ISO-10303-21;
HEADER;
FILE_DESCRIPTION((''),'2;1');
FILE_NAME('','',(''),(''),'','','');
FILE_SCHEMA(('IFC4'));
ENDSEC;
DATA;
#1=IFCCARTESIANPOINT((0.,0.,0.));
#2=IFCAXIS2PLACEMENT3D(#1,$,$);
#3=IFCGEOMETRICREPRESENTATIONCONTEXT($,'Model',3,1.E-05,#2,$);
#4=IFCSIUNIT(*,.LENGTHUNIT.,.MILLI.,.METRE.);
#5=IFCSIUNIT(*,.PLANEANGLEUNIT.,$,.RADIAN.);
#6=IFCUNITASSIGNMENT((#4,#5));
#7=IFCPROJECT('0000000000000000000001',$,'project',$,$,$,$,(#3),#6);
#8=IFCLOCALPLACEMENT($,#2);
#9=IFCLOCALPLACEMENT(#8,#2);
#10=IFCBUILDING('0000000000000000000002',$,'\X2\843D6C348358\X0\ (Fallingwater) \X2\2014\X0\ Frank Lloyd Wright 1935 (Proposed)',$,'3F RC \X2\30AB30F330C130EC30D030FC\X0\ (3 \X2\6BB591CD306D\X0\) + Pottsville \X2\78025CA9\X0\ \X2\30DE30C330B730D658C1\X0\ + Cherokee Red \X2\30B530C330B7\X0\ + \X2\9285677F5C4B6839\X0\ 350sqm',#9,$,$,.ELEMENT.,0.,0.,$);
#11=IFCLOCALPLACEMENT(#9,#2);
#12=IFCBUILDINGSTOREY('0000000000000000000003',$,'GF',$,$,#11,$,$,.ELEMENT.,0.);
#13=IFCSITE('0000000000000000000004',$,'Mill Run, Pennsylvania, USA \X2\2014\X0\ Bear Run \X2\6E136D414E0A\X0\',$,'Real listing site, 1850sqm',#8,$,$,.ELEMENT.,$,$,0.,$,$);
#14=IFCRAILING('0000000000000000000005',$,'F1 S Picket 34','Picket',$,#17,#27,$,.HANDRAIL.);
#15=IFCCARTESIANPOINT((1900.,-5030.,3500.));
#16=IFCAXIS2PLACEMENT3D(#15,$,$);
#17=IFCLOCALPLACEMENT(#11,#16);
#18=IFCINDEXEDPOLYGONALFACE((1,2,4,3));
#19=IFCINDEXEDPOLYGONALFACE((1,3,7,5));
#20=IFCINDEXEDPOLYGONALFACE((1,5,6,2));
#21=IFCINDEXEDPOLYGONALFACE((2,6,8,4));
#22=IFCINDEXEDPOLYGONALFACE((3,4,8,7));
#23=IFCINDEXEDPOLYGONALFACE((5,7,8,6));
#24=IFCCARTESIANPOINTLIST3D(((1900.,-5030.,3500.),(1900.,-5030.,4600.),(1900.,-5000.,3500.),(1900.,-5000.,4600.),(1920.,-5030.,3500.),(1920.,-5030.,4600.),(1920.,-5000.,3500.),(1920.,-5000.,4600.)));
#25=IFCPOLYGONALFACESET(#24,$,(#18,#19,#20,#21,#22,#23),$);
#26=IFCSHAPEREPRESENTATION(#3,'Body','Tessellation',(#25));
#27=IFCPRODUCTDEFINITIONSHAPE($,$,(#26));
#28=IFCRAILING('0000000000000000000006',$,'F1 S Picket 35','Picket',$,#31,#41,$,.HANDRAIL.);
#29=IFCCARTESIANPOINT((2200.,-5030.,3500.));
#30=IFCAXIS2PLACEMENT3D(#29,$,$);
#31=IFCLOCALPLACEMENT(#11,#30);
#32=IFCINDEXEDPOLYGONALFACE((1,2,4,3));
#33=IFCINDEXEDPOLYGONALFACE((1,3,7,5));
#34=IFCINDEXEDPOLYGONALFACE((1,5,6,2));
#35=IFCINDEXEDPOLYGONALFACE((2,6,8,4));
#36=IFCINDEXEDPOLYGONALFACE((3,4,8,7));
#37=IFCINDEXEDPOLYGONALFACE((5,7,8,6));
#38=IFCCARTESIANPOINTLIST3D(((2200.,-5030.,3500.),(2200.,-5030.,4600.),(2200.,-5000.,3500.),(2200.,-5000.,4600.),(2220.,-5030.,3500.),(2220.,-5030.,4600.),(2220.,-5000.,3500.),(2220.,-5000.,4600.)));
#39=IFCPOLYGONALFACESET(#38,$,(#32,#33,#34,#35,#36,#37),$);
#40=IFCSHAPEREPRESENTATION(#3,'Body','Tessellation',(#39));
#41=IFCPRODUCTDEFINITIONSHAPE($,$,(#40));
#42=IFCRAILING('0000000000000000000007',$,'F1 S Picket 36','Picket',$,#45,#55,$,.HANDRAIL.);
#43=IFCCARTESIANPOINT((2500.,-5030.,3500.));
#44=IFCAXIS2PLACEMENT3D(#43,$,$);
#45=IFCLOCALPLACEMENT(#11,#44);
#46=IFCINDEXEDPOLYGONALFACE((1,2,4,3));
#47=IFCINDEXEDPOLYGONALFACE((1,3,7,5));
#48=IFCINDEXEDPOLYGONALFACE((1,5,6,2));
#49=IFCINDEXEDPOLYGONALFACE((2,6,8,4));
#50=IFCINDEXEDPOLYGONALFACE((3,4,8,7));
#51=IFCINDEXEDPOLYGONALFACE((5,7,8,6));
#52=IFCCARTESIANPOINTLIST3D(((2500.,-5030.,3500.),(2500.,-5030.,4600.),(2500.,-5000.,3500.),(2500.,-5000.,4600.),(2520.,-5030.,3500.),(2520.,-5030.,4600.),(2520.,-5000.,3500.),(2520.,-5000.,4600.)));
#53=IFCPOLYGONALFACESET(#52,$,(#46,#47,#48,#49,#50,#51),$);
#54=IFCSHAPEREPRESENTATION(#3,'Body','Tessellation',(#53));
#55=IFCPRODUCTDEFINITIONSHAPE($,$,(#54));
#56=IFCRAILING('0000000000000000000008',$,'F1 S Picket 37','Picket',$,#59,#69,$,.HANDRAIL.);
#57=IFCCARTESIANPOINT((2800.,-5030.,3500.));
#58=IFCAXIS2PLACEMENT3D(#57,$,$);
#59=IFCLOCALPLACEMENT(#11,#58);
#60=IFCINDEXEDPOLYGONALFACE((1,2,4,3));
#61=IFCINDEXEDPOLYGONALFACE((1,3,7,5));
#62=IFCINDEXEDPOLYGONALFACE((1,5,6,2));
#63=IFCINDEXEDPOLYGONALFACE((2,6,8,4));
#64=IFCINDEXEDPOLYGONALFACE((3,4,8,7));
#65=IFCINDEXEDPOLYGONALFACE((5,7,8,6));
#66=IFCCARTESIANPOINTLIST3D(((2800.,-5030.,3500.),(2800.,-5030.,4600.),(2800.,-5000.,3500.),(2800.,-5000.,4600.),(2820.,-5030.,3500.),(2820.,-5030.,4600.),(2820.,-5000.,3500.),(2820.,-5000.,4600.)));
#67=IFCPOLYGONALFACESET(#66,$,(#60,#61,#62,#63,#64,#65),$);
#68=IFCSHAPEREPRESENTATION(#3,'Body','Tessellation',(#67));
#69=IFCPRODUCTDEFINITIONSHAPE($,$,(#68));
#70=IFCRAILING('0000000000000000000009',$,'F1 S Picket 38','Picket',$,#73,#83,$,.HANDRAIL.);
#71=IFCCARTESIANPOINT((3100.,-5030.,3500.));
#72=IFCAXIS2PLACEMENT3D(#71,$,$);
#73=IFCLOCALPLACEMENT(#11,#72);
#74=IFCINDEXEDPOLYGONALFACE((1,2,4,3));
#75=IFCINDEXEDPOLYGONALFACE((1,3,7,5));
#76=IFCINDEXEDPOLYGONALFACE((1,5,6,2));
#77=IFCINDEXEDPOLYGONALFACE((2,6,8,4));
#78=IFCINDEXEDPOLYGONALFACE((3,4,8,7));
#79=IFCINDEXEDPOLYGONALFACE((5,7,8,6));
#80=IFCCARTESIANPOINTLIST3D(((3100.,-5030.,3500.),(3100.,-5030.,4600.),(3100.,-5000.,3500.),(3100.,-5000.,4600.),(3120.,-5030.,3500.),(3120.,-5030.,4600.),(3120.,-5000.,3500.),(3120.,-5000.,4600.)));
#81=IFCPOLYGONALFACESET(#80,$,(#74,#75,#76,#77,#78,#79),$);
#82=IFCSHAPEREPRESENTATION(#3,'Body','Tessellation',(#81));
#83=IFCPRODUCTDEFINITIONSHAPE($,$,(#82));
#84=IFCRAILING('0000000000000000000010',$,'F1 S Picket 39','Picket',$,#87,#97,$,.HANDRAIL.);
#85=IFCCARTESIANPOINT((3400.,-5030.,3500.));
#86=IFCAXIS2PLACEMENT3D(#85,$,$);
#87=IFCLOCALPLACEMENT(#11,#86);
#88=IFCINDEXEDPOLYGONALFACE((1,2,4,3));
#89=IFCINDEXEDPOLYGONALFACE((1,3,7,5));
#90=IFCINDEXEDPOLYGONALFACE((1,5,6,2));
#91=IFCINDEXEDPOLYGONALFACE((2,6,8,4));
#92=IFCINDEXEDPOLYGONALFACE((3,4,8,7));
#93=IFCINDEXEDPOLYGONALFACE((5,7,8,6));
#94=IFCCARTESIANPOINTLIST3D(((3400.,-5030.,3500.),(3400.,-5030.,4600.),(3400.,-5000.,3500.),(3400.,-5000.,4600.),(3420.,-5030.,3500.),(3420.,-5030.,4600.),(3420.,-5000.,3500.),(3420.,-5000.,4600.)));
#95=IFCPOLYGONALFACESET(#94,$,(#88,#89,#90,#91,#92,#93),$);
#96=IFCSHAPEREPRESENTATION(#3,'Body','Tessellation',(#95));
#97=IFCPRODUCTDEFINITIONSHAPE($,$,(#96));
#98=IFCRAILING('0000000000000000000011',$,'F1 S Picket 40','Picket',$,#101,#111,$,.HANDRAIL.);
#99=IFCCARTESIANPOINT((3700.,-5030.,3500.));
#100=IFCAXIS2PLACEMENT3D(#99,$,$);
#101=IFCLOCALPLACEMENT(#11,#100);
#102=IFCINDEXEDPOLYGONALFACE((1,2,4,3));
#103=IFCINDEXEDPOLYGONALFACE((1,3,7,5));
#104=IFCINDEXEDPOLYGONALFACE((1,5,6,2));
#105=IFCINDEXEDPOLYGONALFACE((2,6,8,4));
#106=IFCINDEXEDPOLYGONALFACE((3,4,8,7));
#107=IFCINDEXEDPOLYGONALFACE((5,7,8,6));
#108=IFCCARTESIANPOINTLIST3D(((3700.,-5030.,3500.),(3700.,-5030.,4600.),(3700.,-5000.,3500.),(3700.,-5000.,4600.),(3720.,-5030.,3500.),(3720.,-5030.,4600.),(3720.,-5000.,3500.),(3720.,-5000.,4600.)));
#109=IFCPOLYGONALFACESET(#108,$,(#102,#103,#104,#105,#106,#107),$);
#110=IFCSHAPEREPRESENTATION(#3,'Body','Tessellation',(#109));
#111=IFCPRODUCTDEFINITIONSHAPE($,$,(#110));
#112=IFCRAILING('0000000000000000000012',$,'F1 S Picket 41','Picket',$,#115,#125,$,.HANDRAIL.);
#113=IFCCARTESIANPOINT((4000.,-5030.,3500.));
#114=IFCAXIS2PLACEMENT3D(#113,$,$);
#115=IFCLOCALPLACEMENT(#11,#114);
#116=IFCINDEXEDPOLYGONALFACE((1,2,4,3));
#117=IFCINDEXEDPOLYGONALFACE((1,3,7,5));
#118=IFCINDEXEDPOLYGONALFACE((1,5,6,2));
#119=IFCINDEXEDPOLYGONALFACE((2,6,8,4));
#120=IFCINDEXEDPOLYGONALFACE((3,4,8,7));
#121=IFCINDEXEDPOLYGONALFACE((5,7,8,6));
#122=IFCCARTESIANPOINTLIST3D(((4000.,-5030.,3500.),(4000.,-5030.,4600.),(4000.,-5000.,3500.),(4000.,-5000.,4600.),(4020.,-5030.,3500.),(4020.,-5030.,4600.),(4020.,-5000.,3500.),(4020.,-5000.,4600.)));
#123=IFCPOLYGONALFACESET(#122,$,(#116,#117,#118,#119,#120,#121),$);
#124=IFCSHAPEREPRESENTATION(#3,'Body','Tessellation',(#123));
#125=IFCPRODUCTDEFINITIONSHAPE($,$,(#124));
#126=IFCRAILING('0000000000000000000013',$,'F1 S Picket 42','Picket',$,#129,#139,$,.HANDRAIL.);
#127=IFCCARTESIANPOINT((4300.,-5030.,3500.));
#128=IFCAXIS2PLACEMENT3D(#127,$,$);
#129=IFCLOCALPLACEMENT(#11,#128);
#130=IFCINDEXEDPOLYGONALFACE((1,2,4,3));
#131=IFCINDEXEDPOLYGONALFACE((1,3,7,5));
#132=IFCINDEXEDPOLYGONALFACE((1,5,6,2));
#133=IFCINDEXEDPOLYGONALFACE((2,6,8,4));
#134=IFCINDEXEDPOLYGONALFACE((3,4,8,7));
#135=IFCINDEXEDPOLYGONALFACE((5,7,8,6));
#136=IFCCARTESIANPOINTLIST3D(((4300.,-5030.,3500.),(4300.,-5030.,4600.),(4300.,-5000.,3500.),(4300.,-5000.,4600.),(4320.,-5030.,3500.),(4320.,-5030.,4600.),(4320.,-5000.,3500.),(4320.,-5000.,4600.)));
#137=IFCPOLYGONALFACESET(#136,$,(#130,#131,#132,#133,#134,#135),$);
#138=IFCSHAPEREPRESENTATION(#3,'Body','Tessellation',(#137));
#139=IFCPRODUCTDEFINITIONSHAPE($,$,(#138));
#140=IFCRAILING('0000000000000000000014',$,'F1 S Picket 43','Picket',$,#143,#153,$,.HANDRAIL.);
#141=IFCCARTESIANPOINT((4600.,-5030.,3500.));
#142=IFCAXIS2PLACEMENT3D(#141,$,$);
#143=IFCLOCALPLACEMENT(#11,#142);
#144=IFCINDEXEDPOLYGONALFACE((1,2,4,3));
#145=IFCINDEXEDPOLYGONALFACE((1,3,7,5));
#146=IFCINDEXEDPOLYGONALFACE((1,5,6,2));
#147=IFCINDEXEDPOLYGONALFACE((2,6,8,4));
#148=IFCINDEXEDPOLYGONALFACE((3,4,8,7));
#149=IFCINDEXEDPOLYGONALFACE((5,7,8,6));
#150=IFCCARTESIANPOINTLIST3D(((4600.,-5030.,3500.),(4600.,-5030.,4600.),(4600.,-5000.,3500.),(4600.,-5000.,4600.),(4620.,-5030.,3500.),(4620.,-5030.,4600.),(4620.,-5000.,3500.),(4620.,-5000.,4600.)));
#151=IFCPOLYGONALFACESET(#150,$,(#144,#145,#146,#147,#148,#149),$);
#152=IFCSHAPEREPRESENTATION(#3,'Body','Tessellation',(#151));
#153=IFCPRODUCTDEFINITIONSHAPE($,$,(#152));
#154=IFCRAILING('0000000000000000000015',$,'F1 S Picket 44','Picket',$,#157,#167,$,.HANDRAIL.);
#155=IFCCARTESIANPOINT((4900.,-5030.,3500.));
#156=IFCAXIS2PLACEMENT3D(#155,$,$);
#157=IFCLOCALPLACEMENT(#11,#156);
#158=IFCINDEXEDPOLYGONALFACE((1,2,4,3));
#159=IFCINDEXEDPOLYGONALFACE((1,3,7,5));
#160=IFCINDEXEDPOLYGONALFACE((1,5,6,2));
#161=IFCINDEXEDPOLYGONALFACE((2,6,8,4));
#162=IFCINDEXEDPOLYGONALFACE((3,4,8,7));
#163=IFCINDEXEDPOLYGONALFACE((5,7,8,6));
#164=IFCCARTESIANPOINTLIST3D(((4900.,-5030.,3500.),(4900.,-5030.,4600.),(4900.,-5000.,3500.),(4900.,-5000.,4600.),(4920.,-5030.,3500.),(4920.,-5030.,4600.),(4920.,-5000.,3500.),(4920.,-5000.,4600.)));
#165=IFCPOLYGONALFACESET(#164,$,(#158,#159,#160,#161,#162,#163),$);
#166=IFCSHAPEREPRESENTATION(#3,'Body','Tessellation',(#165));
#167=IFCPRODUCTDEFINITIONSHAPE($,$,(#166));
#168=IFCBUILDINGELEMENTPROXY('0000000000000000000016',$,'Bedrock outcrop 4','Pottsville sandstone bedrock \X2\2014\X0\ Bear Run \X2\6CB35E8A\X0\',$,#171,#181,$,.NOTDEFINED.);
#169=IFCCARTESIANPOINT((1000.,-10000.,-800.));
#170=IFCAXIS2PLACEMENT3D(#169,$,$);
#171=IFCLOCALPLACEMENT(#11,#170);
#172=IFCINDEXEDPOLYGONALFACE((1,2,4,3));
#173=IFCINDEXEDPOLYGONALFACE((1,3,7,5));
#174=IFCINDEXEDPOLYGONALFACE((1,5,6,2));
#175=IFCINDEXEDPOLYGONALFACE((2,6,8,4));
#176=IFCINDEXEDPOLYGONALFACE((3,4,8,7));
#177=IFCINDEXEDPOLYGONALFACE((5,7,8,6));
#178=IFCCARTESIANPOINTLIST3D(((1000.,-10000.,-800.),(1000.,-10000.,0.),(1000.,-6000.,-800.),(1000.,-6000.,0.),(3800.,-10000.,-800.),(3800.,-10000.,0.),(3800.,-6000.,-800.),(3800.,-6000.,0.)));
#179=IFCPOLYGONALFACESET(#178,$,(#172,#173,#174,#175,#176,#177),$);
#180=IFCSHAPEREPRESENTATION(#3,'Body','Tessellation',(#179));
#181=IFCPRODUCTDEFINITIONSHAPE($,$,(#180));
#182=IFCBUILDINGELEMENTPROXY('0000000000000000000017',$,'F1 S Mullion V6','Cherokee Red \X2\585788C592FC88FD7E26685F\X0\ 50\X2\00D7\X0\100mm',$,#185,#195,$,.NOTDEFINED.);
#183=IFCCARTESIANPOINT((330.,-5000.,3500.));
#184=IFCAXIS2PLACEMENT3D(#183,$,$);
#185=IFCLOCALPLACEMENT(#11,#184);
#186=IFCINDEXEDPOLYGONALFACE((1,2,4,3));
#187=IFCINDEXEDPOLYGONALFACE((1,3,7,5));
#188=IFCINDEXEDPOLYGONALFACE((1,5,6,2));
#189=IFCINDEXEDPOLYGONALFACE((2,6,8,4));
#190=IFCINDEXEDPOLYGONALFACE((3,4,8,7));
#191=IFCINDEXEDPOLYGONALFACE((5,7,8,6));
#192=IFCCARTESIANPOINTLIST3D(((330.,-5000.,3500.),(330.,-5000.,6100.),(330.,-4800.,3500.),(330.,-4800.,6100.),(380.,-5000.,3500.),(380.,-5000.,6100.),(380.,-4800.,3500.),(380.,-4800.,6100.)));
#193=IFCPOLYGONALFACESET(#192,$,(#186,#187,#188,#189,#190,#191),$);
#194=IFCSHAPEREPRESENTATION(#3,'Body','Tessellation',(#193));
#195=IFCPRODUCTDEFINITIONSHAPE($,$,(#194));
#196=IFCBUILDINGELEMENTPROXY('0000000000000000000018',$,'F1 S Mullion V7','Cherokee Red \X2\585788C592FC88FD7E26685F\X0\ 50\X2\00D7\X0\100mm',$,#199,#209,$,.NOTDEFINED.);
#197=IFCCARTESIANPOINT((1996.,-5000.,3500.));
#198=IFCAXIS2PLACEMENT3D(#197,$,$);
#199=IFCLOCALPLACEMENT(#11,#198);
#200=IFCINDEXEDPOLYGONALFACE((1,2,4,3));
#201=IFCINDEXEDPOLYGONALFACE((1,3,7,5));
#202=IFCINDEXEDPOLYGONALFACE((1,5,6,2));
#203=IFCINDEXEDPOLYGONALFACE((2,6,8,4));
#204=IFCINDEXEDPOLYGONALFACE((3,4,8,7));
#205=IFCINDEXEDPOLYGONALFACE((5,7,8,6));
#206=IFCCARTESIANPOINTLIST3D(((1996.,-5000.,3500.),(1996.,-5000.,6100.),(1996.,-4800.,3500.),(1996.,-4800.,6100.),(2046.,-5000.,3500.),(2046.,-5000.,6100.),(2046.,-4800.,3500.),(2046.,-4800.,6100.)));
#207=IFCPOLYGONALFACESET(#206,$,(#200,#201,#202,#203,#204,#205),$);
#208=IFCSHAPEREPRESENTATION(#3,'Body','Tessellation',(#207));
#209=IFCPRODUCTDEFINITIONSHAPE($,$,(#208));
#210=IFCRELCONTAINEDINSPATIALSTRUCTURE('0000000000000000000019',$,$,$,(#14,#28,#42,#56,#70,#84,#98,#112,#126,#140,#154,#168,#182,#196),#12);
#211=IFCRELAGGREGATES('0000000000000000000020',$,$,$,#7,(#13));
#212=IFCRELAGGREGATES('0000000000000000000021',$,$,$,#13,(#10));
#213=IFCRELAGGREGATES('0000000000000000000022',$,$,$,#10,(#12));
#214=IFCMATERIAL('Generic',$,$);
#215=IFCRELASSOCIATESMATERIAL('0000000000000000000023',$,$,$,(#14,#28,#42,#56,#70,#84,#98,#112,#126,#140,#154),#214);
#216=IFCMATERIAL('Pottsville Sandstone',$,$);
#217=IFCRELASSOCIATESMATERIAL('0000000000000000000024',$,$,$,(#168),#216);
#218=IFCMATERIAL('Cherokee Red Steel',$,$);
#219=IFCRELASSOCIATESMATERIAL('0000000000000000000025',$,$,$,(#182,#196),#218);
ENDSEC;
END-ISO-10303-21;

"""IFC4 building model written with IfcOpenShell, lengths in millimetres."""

from ifc_helpers import new_model, si_unit, frame, frame_2d, origin, place, context, project, spatial, rectangle, extrude, material, element, save


model = new_model("IFC4")

# Units and contexts
model_context = context("Model", 3, precision=1e-05, world=origin())
ifc_project = project(units=[si_unit("LENGTHUNIT", "METRE", prefix="MILLI"), si_unit("PLANEANGLEUNIT", "RADIAN")], contexts=[model_context])

# Site, building, storey
site_placement = place(None, origin())
site = spatial("IfcSite", under=ifc_project, at=site_placement, Name="Mill Run, Pennsylvania, USA — Bear Run 渓流上", ObjectType="Real listing site, 1850sqm", CompositionType="ELEMENT", RefElevation=0.0)
building_placement = place(site_placement, origin())
building = spatial("IfcBuilding", under=site, at=building_placement, Name="落水荘 (Fallingwater) — Frank Lloyd Wright 1935 (Proposed)", ObjectType="3F RC カンチレバー (3 段重ね) + Pottsville 砂岩 マッシブ壁 + Cherokee Red サッシ + 銅板屋根 350sqm", CompositionType="ELEMENT", ElevationOfRefHeight=0.0, ElevationOfTerrain=0.0)
storey_placement = place(building_placement, origin())
storey = spatial("IfcBuildingStorey", under=building, at=storey_placement, Name="GF", CompositionType="ELEMENT", Elevation=0.0)

# Shared definitions
ifc_material_1 = material(Name="Cherokee Red Steel")

# Railings
ifc_material_2 = material(Name="Generic")
railing_1_placement = place(storey_placement, frame((1900.0, -5030.0, 3500.0)))
element("IfcRailing", 1, at=railing_1_placement, inside=storey, material=ifc_material_2, Name="F1 S Picket 34", Description="Picket", PredefinedType="HANDRAIL", context=model_context, shape_type="SweptSolid", body=[
    extrude(rectangle(XDim=20.0, YDim=30.0, at=frame_2d((10.0, 15.0))), frame((1900.0, -5030.0, 3500.0)), (0.0, 0.0, 1.0), 1100.0),
])
railing_2_placement = place(storey_placement, frame((2200.0, -5030.0, 3500.0)))
element("IfcRailing", 2, at=railing_2_placement, inside=storey, material=ifc_material_2, Name="F1 S Picket 35", Description="Picket", PredefinedType="HANDRAIL", context=model_context, shape_type="SweptSolid", body=[
    extrude(rectangle(XDim=20.0, YDim=30.0, at=frame_2d((10.0, 15.0))), frame((2200.0, -5030.0, 3500.0)), (0.0, 0.0, 1.0), 1100.0),
])
railing_3_placement = place(storey_placement, frame((2500.0, -5030.0, 3500.0)))
element("IfcRailing", 3, at=railing_3_placement, inside=storey, material=ifc_material_2, Name="F1 S Picket 36", Description="Picket", PredefinedType="HANDRAIL", context=model_context, shape_type="SweptSolid", body=[
    extrude(rectangle(XDim=20.0, YDim=30.0, at=frame_2d((10.0, 15.0))), frame((2500.0, -5030.0, 3500.0)), (0.0, 0.0, 1.0), 1100.0),
])
railing_4_placement = place(storey_placement, frame((2800.0, -5030.0, 3500.0)))
element("IfcRailing", 4, at=railing_4_placement, inside=storey, material=ifc_material_2, Name="F1 S Picket 37", Description="Picket", PredefinedType="HANDRAIL", context=model_context, shape_type="SweptSolid", body=[
    extrude(rectangle(XDim=20.0, YDim=30.0, at=frame_2d((10.0, 15.0))), frame((2800.0, -5030.0, 3500.0)), (0.0, 0.0, 1.0), 1100.0),
])
railing_5_placement = place(storey_placement, frame((3100.0, -5030.0, 3500.0)))
element("IfcRailing", 5, at=railing_5_placement, inside=storey, material=ifc_material_2, Name="F1 S Picket 38", Description="Picket", PredefinedType="HANDRAIL", context=model_context, shape_type="SweptSolid", body=[
    extrude(rectangle(XDim=20.0, YDim=30.0, at=frame_2d((10.0, 15.0))), frame((3100.0, -5030.0, 3500.0)), (0.0, 0.0, 1.0), 1100.0),
])
railing_6_placement = place(storey_placement, frame((3400.0, -5030.0, 3500.0)))
element("IfcRailing", 6, at=railing_6_placement, inside=storey, material=ifc_material_2, Name="F1 S Picket 39", Description="Picket", PredefinedType="HANDRAIL", context=model_context, shape_type="SweptSolid", body=[
    extrude(rectangle(XDim=20.0, YDim=30.0, at=frame_2d((10.0, 15.0))), frame((3400.0, -5030.0, 3500.0)), (0.0, 0.0, 1.0), 1100.0),
])
railing_7_placement = place(storey_placement, frame((3700.0, -5030.0, 3500.0)))
element("IfcRailing", 7, at=railing_7_placement, inside=storey, material=ifc_material_2, Name="F1 S Picket 40", Description="Picket", PredefinedType="HANDRAIL", context=model_context, shape_type="SweptSolid", body=[
    extrude(rectangle(XDim=20.0, YDim=30.0, at=frame_2d((10.0, 15.0))), frame((3700.0, -5030.0, 3500.0)), (0.0, 0.0, 1.0), 1100.0),
])
railing_8_placement = place(storey_placement, frame((4000.0, -5030.0, 3500.0)))
element("IfcRailing", 8, at=railing_8_placement, inside=storey, material=ifc_material_2, Name="F1 S Picket 41", Description="Picket", PredefinedType="HANDRAIL", context=model_context, shape_type="SweptSolid", body=[
    extrude(rectangle(XDim=20.0, YDim=30.0, at=frame_2d((10.0, 15.0))), frame((4000.0, -5030.0, 3500.0)), (0.0, 0.0, 1.0), 1100.0),
])
railing_9_placement = place(storey_placement, frame((4300.0, -5030.0, 3500.0)))
element("IfcRailing", 9, at=railing_9_placement, inside=storey, material=ifc_material_2, Name="F1 S Picket 42", Description="Picket", PredefinedType="HANDRAIL", context=model_context, shape_type="SweptSolid", body=[
    extrude(rectangle(XDim=20.0, YDim=30.0, at=frame_2d((10.0, 15.0))), frame((4300.0, -5030.0, 3500.0)), (0.0, 0.0, 1.0), 1100.0),
])
railing_10_placement = place(storey_placement, frame((4600.0, -5030.0, 3500.0)))
element("IfcRailing", 10, at=railing_10_placement, inside=storey, material=ifc_material_2, Name="F1 S Picket 43", Description="Picket", PredefinedType="HANDRAIL", context=model_context, shape_type="SweptSolid", body=[
    extrude(rectangle(XDim=20.0, YDim=30.0, at=frame_2d((10.0, 15.0))), frame((4600.0, -5030.0, 3500.0)), (0.0, 0.0, 1.0), 1100.0),
])
railing_11_placement = place(storey_placement, frame((4900.0, -5030.0, 3500.0)))
element("IfcRailing", 11, at=railing_11_placement, inside=storey, material=ifc_material_2, Name="F1 S Picket 44", Description="Picket", PredefinedType="HANDRAIL", context=model_context, shape_type="SweptSolid", body=[
    extrude(rectangle(XDim=20.0, YDim=30.0, at=frame_2d((10.0, 15.0))), frame((4900.0, -5030.0, 3500.0)), (0.0, 0.0, 1.0), 1100.0),
])

# Building element proxies
ifc_material_3 = material(Name="Pottsville Sandstone")
proxy_1_placement = place(storey_placement, frame((1000.0, -10000.0, -800.0)))
element("IfcBuildingElementProxy", 12, at=proxy_1_placement, inside=storey, material=ifc_material_3, Name="Bedrock outcrop 4", Description="Pottsville sandstone bedrock — Bear Run 河床", PredefinedType="NOTDEFINED", context=model_context, shape_type="SweptSolid", body=[
    extrude(rectangle(XDim=2800.0, YDim=4000.0, at=frame_2d((1400.0, 2000.0))), frame((1000.0, -10000.0, -800.0)), (0.0, 0.0, 1.0), 800.0),
])
proxy_2_placement = place(storey_placement, frame((330.0, -5000.0, 3500.0)))
element("IfcBuildingElementProxy", 13, at=proxy_2_placement, inside=storey, material=ifc_material_1, Name="F1 S Mullion V6", Description="Cherokee Red 塗装鋼製縦桟 50×100mm", PredefinedType="NOTDEFINED", context=model_context, shape_type="SweptSolid", body=[
    extrude(rectangle(XDim=50.0, YDim=200.0, at=frame_2d((25.0, 100.0))), frame((330.0, -5000.0, 3500.0)), (0.0, 0.0, 1.0), 2600.0),
])
proxy_3_placement = place(storey_placement, frame((1996.0, -5000.0, 3500.0)))
element("IfcBuildingElementProxy", 14, at=proxy_3_placement, inside=storey, material=ifc_material_1, Name="F1 S Mullion V7", Description="Cherokee Red 塗装鋼製縦桟 50×100mm", PredefinedType="NOTDEFINED", context=model_context, shape_type="SweptSolid", body=[
    extrude(rectangle(XDim=50.0, YDim=200.0, at=frame_2d((25.0, 100.0))), frame((1996.0, -5000.0, 3500.0)), (0.0, 0.0, 1.0), 2600.0),
])

save(model, "model.ifc")
